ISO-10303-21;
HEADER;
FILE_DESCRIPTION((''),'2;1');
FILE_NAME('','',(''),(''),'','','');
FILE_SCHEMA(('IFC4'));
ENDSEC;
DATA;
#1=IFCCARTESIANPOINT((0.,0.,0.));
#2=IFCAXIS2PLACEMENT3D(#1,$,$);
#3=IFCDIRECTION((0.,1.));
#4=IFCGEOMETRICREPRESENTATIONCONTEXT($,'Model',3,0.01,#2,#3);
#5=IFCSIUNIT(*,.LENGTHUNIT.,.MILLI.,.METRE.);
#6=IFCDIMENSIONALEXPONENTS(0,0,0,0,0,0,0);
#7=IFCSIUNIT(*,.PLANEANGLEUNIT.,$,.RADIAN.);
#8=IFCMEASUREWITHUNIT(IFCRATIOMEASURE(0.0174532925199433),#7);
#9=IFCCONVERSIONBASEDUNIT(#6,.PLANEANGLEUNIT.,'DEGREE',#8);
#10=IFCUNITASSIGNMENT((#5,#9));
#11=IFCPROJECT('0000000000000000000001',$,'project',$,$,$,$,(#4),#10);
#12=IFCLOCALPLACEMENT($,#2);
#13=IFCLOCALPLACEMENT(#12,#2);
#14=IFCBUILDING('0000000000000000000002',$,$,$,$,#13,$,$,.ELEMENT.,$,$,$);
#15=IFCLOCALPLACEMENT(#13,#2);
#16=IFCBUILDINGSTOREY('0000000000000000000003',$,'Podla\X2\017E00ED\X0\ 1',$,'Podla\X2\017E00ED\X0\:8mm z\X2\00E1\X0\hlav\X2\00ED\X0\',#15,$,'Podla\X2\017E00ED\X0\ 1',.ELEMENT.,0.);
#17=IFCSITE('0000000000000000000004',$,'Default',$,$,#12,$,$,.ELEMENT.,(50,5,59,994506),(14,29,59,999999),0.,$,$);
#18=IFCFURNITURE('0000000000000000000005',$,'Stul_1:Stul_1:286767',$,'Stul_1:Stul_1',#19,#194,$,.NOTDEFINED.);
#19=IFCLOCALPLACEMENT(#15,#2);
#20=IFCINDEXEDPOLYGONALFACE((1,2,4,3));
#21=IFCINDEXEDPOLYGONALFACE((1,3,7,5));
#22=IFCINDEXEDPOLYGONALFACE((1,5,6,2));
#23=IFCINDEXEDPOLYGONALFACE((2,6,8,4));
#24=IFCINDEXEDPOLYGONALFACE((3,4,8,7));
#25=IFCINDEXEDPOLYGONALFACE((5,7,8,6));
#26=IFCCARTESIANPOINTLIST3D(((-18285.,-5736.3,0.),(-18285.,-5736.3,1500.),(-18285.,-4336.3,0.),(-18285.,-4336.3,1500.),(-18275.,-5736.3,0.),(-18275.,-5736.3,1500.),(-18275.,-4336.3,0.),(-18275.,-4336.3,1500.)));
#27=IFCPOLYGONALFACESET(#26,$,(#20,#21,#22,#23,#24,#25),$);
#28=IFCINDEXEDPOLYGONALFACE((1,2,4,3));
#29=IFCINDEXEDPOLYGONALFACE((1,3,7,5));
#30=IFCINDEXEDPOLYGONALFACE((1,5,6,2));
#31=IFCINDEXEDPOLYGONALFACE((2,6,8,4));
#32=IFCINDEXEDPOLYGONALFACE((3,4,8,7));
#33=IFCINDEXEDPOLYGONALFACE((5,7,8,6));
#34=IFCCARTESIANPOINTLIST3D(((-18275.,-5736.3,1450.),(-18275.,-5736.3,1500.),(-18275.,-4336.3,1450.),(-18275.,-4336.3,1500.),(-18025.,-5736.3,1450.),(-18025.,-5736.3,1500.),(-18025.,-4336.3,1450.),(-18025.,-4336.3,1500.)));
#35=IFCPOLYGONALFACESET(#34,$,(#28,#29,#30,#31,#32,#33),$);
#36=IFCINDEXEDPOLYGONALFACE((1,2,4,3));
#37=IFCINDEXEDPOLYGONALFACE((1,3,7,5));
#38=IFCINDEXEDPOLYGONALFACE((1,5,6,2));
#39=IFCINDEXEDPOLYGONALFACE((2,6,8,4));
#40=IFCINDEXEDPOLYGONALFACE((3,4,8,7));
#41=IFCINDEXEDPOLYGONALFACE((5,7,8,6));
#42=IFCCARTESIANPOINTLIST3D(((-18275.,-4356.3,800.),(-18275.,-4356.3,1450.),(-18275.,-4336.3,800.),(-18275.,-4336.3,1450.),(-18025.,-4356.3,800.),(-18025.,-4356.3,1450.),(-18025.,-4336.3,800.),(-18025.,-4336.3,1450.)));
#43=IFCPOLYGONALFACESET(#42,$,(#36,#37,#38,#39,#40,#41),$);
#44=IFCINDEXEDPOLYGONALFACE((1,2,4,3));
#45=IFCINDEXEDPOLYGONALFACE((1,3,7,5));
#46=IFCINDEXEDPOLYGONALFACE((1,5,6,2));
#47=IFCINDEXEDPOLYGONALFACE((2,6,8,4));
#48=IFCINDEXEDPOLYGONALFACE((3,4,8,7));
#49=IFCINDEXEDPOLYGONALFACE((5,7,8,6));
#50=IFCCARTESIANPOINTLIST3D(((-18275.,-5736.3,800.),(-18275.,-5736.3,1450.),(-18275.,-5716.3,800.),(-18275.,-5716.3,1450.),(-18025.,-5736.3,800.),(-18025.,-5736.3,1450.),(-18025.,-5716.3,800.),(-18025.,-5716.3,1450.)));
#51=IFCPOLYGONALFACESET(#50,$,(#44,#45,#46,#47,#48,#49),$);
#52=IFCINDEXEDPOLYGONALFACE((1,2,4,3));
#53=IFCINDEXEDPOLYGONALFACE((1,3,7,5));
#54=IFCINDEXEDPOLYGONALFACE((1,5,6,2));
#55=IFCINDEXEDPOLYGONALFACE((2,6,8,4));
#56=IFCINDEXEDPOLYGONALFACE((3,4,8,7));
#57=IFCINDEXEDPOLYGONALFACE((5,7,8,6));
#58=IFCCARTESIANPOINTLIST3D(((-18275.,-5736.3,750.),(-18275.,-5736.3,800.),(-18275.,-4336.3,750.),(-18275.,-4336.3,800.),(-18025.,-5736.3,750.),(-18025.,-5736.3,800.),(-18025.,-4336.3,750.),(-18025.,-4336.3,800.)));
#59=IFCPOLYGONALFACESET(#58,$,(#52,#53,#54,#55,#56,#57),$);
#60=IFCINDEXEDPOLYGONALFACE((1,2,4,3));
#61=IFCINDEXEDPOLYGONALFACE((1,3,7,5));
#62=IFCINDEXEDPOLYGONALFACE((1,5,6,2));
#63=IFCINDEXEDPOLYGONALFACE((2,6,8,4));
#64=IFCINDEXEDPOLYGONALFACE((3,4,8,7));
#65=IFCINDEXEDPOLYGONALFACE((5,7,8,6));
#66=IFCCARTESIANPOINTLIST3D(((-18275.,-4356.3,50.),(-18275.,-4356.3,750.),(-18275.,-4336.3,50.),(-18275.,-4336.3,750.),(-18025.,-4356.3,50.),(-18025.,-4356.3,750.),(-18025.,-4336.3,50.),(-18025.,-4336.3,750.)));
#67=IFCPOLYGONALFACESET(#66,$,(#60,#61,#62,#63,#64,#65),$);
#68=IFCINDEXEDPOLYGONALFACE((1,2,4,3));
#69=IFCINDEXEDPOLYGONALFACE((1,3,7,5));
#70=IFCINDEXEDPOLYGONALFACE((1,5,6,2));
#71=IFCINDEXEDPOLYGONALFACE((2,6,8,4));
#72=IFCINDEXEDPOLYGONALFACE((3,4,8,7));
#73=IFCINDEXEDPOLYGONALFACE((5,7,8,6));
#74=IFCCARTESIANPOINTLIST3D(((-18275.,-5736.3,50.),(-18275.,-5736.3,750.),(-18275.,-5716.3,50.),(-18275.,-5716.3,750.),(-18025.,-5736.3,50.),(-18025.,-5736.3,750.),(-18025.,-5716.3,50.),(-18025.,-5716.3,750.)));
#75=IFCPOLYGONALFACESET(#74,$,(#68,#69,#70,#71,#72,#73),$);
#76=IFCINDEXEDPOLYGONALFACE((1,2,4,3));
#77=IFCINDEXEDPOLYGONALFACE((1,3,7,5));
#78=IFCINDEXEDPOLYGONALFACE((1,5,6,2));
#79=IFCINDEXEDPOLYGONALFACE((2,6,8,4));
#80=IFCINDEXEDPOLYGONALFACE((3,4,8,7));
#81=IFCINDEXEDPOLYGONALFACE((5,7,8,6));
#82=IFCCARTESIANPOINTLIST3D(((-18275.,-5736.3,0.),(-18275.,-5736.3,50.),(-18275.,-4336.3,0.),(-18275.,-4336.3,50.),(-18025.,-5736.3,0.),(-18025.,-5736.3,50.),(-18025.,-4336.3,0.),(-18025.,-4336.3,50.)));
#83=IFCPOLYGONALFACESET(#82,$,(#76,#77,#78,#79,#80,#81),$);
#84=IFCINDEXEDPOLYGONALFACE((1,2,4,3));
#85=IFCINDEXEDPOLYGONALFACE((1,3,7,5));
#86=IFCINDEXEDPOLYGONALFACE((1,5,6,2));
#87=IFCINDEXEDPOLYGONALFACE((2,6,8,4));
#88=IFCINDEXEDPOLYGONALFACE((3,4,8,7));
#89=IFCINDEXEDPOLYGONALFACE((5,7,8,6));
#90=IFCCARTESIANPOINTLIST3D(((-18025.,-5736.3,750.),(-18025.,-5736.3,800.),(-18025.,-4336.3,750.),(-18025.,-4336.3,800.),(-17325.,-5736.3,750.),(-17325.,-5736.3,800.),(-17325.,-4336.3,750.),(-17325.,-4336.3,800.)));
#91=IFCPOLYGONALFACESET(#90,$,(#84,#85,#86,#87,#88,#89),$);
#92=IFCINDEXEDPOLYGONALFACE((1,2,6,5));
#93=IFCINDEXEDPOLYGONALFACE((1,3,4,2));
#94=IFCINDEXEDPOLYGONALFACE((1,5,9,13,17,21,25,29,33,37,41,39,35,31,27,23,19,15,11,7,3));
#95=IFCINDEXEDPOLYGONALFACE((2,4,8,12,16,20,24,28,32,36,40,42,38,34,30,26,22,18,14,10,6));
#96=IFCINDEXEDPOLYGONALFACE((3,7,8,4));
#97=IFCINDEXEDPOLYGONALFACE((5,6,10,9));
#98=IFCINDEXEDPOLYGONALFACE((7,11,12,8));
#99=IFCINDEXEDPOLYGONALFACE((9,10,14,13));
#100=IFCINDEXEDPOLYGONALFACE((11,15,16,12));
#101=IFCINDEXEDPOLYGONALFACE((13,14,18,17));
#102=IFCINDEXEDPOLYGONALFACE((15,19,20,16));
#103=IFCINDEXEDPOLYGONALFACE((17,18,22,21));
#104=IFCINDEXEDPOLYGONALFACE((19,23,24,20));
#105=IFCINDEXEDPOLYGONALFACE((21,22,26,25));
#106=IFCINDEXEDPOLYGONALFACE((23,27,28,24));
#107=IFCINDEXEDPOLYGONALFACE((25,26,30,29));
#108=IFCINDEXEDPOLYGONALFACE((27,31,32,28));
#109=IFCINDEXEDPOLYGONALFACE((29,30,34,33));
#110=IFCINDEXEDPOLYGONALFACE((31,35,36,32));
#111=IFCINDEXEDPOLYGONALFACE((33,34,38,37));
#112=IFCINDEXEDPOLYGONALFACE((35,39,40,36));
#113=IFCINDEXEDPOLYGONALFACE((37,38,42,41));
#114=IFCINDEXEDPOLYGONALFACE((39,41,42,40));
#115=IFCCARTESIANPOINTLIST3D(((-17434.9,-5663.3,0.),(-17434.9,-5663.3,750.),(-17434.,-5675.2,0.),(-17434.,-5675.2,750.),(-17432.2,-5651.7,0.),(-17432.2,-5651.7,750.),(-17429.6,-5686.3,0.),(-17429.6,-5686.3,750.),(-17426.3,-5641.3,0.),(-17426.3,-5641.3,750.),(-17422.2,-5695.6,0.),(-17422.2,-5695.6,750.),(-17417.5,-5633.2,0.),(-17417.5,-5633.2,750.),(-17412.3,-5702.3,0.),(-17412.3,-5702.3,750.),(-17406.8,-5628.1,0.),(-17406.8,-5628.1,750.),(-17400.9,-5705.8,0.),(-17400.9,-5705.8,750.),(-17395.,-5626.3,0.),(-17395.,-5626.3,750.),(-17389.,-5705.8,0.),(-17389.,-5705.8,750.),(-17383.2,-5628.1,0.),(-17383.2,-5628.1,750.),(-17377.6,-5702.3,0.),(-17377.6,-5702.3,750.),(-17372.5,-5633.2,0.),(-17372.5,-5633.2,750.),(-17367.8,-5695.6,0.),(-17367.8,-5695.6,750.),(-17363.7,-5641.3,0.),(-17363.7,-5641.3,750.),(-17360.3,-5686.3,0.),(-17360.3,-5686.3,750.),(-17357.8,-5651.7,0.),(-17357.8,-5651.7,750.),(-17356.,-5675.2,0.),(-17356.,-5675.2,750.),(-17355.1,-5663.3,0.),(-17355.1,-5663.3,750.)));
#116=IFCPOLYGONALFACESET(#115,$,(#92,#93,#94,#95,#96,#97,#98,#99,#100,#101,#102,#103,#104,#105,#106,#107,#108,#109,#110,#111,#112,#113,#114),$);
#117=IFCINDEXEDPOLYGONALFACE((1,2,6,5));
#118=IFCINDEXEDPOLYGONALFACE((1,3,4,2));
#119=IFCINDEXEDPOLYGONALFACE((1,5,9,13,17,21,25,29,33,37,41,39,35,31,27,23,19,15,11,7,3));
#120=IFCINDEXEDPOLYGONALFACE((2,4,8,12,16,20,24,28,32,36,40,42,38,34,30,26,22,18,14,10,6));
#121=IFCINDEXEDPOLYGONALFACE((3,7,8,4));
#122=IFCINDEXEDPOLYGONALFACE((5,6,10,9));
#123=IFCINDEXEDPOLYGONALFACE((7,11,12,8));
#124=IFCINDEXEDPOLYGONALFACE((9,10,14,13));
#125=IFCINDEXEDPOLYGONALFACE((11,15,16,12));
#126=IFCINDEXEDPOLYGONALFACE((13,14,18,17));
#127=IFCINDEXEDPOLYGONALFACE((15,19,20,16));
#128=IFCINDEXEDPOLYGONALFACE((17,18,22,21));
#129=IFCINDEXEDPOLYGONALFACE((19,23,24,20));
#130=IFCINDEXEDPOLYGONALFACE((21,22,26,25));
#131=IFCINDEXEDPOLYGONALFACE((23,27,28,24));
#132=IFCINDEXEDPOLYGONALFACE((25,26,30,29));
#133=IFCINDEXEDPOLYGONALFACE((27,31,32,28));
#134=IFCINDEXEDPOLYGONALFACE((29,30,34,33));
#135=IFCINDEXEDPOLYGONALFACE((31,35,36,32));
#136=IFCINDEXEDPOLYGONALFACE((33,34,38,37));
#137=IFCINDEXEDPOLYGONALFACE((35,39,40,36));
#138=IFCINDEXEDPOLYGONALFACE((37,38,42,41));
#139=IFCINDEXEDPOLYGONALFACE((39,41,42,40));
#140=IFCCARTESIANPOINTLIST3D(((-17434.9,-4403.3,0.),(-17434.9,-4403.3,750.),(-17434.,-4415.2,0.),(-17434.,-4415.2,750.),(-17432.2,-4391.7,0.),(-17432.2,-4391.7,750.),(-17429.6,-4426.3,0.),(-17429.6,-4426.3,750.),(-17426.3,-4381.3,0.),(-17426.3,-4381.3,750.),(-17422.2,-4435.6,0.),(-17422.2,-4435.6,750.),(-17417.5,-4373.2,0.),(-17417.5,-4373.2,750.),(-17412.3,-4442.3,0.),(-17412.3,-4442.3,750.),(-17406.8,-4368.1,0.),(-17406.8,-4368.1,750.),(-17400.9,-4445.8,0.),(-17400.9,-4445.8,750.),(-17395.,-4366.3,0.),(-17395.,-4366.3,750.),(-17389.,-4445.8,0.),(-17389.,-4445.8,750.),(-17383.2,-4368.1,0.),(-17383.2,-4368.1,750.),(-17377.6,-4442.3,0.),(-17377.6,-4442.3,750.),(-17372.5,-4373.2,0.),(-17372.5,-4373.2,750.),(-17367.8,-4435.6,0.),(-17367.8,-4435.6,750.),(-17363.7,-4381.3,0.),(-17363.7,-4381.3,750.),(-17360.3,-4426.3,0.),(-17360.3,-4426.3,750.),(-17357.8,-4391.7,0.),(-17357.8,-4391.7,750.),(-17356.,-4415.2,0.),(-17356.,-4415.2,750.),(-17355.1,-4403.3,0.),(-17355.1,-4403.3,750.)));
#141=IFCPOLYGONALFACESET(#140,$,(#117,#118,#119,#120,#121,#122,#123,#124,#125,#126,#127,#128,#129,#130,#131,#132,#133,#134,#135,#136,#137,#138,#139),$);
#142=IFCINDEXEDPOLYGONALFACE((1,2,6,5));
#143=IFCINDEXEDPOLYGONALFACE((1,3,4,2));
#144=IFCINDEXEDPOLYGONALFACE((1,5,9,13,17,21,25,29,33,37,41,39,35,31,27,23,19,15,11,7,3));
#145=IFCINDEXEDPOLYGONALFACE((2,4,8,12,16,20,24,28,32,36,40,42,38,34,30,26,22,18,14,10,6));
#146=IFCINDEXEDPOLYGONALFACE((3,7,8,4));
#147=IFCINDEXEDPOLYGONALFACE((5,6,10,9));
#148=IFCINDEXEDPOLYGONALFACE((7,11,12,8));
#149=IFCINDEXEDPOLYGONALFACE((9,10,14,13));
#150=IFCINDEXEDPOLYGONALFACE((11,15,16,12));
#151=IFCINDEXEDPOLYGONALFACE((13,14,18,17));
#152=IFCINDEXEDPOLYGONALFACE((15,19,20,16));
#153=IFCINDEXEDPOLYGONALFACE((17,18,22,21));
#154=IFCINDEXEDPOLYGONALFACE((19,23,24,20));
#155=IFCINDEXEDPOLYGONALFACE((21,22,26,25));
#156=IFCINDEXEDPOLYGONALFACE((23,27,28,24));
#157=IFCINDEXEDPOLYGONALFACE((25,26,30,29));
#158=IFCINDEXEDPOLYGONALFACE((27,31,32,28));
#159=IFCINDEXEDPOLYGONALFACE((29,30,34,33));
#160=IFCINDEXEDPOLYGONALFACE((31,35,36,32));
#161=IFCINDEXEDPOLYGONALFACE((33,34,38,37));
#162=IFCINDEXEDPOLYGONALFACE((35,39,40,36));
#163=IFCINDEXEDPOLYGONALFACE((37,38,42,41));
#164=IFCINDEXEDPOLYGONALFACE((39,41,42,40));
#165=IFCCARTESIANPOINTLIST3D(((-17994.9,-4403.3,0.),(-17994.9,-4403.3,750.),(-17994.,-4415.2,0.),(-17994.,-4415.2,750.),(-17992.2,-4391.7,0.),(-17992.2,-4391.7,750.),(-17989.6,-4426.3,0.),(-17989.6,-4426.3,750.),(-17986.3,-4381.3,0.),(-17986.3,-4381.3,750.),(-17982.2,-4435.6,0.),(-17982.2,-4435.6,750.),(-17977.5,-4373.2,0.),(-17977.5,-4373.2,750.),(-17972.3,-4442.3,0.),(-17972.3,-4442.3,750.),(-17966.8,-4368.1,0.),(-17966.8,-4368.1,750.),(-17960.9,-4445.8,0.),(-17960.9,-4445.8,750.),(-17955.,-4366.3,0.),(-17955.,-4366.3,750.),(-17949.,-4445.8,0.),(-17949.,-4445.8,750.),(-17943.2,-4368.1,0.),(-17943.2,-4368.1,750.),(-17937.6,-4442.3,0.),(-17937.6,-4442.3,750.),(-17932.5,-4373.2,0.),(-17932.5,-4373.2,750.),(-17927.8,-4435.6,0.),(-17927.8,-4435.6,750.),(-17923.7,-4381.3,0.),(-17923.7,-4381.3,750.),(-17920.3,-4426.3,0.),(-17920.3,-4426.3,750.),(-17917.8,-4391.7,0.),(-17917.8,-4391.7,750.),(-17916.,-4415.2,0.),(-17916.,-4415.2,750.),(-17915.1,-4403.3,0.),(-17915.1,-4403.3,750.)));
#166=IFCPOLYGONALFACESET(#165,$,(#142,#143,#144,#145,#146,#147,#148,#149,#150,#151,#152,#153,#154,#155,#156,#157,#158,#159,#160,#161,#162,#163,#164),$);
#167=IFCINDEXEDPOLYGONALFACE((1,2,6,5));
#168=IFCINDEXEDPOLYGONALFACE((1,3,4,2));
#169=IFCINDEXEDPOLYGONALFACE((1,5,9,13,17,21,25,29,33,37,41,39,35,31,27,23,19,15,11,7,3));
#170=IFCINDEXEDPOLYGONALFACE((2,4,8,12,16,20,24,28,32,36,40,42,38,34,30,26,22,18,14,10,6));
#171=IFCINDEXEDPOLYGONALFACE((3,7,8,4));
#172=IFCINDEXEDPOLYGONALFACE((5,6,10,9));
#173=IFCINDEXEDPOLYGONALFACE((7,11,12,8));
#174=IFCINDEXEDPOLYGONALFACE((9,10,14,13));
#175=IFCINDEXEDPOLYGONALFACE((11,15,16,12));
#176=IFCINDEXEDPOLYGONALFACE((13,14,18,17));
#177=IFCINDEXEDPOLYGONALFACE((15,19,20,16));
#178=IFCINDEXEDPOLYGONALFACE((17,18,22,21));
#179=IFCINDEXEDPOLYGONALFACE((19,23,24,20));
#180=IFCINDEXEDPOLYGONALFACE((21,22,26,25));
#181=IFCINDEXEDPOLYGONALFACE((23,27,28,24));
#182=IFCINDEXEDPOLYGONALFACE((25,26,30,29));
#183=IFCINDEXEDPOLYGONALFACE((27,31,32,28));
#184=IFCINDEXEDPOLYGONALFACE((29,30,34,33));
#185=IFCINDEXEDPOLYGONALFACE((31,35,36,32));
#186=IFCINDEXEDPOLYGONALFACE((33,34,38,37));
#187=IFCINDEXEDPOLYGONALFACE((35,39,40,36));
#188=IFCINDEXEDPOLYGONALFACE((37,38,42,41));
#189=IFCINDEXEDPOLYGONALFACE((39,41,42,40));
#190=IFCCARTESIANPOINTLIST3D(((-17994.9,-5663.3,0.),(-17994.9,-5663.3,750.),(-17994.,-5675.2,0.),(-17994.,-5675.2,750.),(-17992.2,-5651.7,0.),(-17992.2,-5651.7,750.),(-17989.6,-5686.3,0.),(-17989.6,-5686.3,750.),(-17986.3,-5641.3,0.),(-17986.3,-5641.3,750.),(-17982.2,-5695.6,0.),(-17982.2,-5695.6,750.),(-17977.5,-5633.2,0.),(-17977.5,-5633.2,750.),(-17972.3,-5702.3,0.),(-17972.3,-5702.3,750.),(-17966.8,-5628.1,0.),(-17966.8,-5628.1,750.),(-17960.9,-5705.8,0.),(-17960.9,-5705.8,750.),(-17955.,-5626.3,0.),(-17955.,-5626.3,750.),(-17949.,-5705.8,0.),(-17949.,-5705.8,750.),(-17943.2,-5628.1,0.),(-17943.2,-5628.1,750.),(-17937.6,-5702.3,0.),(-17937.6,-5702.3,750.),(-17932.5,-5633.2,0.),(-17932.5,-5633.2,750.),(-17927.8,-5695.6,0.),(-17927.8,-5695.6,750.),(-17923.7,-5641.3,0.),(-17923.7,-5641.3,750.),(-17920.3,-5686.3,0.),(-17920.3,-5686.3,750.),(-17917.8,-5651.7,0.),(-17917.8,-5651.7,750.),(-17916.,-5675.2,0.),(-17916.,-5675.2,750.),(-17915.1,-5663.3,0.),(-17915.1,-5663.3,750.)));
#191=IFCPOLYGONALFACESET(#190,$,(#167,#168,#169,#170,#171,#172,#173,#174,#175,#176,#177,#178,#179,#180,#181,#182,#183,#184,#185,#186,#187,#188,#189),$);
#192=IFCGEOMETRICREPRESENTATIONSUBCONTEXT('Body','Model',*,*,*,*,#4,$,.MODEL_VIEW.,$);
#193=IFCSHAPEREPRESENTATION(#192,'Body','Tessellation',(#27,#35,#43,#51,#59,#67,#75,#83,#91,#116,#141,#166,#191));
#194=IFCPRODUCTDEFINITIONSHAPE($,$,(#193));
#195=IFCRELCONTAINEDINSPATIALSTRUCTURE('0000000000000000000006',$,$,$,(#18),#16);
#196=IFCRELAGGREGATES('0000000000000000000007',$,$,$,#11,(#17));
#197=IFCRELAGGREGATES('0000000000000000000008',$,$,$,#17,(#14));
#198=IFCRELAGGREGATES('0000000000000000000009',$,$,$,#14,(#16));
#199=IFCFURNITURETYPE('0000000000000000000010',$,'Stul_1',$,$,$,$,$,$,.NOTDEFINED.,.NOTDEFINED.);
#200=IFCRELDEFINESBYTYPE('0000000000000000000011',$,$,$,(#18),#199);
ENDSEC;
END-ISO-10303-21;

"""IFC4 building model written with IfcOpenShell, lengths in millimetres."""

from ifc_helpers import new_model, entity, si_unit, converted_unit, direction, frame, frame_2d, origin, origin_2d_with_axis, place, context, subcontext, project, spatial, rectangle, circle, extrude, source, transform, mapped, type_object, type_shapes, element, save


model = new_model("IFC4")

# Units and contexts
model_context = context("Model", 3, precision=0.01, world=origin(), true_north=direction((0.0, 1.0)))
body_context = subcontext(model_context, "Body", "Model", "MODEL_VIEW")
ifc_project = project(units=[si_unit("LENGTHUNIT", "METRE", prefix="MILLI"), converted_unit("PLANEANGLEUNIT", "DEGREE", entity("IfcRatioMeasure", 0.0174532925199433), si_unit("PLANEANGLEUNIT", "RADIAN"), dimensions=[0, 0, 0, 0, 0, 0, 0])], contexts=[model_context])

# Site, building, storey
site_placement = place(None, origin())
site = spatial("IfcSite", under=ifc_project, at=site_placement, Name="Default", CompositionType="ELEMENT", RefLatitude=(50, 5, 59, 994506), RefLongitude=(14, 29, 59, 999999), RefElevation=0.0)
building_placement = place(site_placement, origin())
building = spatial("IfcBuilding", under=site, at=building_placement, CompositionType="ELEMENT")
storey_placement = place(building_placement, origin())
storey = spatial("IfcBuildingStorey", under=building, at=storey_placement, Name="Podlaží 1", ObjectType="Podlaží:8mm záhlaví", LongName="Podlaží 1", CompositionType="ELEMENT", Elevation=0.0)

# Furniture
furniture_type = type_object("IfcFurnitureType", Name="Stul_1", AssemblyPlace="NOTDEFINED", PredefinedType="NOTDEFINED")
shared_shape_1 = source(origin(), body_context, "Body", "SweptSolid", [
    extrude(rectangle(XDim=1400.0, YDim=10.0, at=origin_2d_with_axis()), frame((0.0, 605.0, 0.0), z_axis=(0.0, 0.0, 1.0), x_axis=(-1.0, 0.0, 0.0)), (0.0, 0.0, 1.0), 1500.0),
    extrude(rectangle(XDim=1400.0, YDim=250.0, at=frame_2d((0.0, 0.0), x_axis=(1.0, 0.0))), frame((0.0, 475.0, 1450.0), z_axis=(0.0, 0.0, 1.0), x_axis=(-1.0, 0.0, 0.0)), (0.0, 0.0, 1.0), 50.0),
    extrude(rectangle(XDim=20.0, YDim=250.0, at=origin_2d_with_axis()), frame((690.0, 475.0, 800.0), z_axis=(0.0, 0.0, 1.0), x_axis=(-1.0, 0.0, 0.0)), (0.0, 0.0, 1.0), 650.0),
    extrude(rectangle(XDim=20.0, YDim=250.0, at=frame_2d((0.0, 0.0), x_axis=(1.0, 0.0))), frame((-690.0, 475.0, 800.0), z_axis=(0.0, 0.0, 1.0), x_axis=(-1.0, 0.0, 0.0)), (0.0, 0.0, 1.0), 650.0),
    extrude(rectangle(XDim=1400.0, YDim=250.0, at=origin_2d_with_axis()), frame((0.0, 475.0, 750.0), z_axis=(0.0, 0.0, 1.0), x_axis=(-1.0, 0.0, 0.0)), (0.0, 0.0, 1.0), 50.0),
    extrude(rectangle(XDim=20.0, YDim=250.0, at=origin_2d_with_axis()), frame((690.0, 475.0, 50.0), z_axis=(0.0, 0.0, 1.0), x_axis=(-1.0, 0.0, 0.0)), (0.0, 0.0, 1.0), 700.0),
    extrude(rectangle(XDim=20.0, YDim=250.0, at=frame_2d((0.0, 0.0), x_axis=(1.0, 0.0))), frame((-690.0, 475.0, 50.0), z_axis=(0.0, 0.0, 1.0), x_axis=(-1.0, 0.0, 0.0)), (0.0, 0.0, 1.0), 700.0),
    extrude(rectangle(XDim=1400.0, YDim=250.0, at=origin_2d_with_axis()), frame((0.0, 475.0, 0.0), z_axis=(0.0, 0.0, 1.0), x_axis=(-1.0, 0.0, 0.0)), (0.0, 0.0, 1.0), 50.0),
    extrude(rectangle(XDim=1400.0, YDim=700.0, at=origin_2d_with_axis()), frame((0.0, 0.0, 750.0), z_axis=(0.0, 0.0, 1.0), x_axis=(-1.0, 0.0, 0.0)), (0.0, 0.0, 1.0), 50.0),
    extrude(circle(Radius=40.0, at=frame_2d((0.0, 0.0), x_axis=(1.0, 0.0))), frame((-630.0, -280.0, 0.0)), (0.0, 0.0, 1.0), 750.0),
    extrude(circle(Radius=40.0, at=frame_2d((0.0, 0.0), x_axis=(1.0, 0.0))), frame((630.0, -280.0, 0.0)), (0.0, 0.0, 1.0), 750.0),
    extrude(circle(Radius=40.0, at=frame_2d((0.0, 0.0), x_axis=(1.0, 0.0))), frame((630.0, 280.0, 0.0)), (0.0, 0.0, 1.0), 750.0),
    extrude(circle(Radius=40.0, at=frame_2d((0.0, 0.0), x_axis=(1.0, 0.0))), frame((-630.0, 280.0, 0.0)), (0.0, 0.0, 1.0), 750.0),
])
type_shapes(furniture_type, [shared_shape_1])
for number, where, z_axis, x_axis, name in (
    (1, (-17675.0, -5036.3, 0.0), (0.0, 0.0, 1.0), (0.0, 1.0, 0.0), "Stul_1:Stul_1:286767"),
):
    element("IfcFurniture", number, at=place(storey_placement, frame(where, z_axis=z_axis, x_axis=x_axis)), inside=storey, type_object=furniture_type, Name=name, ObjectType="Stul_1:Stul_1", PredefinedType="NOTDEFINED", context=body_context, shape_type="MappedRepresentation", body=[
        mapped(shared_shape_1, transform((0.0, 0.0, 0.0), scale=1.0)),
    ])

save(model, "model.ifc")
